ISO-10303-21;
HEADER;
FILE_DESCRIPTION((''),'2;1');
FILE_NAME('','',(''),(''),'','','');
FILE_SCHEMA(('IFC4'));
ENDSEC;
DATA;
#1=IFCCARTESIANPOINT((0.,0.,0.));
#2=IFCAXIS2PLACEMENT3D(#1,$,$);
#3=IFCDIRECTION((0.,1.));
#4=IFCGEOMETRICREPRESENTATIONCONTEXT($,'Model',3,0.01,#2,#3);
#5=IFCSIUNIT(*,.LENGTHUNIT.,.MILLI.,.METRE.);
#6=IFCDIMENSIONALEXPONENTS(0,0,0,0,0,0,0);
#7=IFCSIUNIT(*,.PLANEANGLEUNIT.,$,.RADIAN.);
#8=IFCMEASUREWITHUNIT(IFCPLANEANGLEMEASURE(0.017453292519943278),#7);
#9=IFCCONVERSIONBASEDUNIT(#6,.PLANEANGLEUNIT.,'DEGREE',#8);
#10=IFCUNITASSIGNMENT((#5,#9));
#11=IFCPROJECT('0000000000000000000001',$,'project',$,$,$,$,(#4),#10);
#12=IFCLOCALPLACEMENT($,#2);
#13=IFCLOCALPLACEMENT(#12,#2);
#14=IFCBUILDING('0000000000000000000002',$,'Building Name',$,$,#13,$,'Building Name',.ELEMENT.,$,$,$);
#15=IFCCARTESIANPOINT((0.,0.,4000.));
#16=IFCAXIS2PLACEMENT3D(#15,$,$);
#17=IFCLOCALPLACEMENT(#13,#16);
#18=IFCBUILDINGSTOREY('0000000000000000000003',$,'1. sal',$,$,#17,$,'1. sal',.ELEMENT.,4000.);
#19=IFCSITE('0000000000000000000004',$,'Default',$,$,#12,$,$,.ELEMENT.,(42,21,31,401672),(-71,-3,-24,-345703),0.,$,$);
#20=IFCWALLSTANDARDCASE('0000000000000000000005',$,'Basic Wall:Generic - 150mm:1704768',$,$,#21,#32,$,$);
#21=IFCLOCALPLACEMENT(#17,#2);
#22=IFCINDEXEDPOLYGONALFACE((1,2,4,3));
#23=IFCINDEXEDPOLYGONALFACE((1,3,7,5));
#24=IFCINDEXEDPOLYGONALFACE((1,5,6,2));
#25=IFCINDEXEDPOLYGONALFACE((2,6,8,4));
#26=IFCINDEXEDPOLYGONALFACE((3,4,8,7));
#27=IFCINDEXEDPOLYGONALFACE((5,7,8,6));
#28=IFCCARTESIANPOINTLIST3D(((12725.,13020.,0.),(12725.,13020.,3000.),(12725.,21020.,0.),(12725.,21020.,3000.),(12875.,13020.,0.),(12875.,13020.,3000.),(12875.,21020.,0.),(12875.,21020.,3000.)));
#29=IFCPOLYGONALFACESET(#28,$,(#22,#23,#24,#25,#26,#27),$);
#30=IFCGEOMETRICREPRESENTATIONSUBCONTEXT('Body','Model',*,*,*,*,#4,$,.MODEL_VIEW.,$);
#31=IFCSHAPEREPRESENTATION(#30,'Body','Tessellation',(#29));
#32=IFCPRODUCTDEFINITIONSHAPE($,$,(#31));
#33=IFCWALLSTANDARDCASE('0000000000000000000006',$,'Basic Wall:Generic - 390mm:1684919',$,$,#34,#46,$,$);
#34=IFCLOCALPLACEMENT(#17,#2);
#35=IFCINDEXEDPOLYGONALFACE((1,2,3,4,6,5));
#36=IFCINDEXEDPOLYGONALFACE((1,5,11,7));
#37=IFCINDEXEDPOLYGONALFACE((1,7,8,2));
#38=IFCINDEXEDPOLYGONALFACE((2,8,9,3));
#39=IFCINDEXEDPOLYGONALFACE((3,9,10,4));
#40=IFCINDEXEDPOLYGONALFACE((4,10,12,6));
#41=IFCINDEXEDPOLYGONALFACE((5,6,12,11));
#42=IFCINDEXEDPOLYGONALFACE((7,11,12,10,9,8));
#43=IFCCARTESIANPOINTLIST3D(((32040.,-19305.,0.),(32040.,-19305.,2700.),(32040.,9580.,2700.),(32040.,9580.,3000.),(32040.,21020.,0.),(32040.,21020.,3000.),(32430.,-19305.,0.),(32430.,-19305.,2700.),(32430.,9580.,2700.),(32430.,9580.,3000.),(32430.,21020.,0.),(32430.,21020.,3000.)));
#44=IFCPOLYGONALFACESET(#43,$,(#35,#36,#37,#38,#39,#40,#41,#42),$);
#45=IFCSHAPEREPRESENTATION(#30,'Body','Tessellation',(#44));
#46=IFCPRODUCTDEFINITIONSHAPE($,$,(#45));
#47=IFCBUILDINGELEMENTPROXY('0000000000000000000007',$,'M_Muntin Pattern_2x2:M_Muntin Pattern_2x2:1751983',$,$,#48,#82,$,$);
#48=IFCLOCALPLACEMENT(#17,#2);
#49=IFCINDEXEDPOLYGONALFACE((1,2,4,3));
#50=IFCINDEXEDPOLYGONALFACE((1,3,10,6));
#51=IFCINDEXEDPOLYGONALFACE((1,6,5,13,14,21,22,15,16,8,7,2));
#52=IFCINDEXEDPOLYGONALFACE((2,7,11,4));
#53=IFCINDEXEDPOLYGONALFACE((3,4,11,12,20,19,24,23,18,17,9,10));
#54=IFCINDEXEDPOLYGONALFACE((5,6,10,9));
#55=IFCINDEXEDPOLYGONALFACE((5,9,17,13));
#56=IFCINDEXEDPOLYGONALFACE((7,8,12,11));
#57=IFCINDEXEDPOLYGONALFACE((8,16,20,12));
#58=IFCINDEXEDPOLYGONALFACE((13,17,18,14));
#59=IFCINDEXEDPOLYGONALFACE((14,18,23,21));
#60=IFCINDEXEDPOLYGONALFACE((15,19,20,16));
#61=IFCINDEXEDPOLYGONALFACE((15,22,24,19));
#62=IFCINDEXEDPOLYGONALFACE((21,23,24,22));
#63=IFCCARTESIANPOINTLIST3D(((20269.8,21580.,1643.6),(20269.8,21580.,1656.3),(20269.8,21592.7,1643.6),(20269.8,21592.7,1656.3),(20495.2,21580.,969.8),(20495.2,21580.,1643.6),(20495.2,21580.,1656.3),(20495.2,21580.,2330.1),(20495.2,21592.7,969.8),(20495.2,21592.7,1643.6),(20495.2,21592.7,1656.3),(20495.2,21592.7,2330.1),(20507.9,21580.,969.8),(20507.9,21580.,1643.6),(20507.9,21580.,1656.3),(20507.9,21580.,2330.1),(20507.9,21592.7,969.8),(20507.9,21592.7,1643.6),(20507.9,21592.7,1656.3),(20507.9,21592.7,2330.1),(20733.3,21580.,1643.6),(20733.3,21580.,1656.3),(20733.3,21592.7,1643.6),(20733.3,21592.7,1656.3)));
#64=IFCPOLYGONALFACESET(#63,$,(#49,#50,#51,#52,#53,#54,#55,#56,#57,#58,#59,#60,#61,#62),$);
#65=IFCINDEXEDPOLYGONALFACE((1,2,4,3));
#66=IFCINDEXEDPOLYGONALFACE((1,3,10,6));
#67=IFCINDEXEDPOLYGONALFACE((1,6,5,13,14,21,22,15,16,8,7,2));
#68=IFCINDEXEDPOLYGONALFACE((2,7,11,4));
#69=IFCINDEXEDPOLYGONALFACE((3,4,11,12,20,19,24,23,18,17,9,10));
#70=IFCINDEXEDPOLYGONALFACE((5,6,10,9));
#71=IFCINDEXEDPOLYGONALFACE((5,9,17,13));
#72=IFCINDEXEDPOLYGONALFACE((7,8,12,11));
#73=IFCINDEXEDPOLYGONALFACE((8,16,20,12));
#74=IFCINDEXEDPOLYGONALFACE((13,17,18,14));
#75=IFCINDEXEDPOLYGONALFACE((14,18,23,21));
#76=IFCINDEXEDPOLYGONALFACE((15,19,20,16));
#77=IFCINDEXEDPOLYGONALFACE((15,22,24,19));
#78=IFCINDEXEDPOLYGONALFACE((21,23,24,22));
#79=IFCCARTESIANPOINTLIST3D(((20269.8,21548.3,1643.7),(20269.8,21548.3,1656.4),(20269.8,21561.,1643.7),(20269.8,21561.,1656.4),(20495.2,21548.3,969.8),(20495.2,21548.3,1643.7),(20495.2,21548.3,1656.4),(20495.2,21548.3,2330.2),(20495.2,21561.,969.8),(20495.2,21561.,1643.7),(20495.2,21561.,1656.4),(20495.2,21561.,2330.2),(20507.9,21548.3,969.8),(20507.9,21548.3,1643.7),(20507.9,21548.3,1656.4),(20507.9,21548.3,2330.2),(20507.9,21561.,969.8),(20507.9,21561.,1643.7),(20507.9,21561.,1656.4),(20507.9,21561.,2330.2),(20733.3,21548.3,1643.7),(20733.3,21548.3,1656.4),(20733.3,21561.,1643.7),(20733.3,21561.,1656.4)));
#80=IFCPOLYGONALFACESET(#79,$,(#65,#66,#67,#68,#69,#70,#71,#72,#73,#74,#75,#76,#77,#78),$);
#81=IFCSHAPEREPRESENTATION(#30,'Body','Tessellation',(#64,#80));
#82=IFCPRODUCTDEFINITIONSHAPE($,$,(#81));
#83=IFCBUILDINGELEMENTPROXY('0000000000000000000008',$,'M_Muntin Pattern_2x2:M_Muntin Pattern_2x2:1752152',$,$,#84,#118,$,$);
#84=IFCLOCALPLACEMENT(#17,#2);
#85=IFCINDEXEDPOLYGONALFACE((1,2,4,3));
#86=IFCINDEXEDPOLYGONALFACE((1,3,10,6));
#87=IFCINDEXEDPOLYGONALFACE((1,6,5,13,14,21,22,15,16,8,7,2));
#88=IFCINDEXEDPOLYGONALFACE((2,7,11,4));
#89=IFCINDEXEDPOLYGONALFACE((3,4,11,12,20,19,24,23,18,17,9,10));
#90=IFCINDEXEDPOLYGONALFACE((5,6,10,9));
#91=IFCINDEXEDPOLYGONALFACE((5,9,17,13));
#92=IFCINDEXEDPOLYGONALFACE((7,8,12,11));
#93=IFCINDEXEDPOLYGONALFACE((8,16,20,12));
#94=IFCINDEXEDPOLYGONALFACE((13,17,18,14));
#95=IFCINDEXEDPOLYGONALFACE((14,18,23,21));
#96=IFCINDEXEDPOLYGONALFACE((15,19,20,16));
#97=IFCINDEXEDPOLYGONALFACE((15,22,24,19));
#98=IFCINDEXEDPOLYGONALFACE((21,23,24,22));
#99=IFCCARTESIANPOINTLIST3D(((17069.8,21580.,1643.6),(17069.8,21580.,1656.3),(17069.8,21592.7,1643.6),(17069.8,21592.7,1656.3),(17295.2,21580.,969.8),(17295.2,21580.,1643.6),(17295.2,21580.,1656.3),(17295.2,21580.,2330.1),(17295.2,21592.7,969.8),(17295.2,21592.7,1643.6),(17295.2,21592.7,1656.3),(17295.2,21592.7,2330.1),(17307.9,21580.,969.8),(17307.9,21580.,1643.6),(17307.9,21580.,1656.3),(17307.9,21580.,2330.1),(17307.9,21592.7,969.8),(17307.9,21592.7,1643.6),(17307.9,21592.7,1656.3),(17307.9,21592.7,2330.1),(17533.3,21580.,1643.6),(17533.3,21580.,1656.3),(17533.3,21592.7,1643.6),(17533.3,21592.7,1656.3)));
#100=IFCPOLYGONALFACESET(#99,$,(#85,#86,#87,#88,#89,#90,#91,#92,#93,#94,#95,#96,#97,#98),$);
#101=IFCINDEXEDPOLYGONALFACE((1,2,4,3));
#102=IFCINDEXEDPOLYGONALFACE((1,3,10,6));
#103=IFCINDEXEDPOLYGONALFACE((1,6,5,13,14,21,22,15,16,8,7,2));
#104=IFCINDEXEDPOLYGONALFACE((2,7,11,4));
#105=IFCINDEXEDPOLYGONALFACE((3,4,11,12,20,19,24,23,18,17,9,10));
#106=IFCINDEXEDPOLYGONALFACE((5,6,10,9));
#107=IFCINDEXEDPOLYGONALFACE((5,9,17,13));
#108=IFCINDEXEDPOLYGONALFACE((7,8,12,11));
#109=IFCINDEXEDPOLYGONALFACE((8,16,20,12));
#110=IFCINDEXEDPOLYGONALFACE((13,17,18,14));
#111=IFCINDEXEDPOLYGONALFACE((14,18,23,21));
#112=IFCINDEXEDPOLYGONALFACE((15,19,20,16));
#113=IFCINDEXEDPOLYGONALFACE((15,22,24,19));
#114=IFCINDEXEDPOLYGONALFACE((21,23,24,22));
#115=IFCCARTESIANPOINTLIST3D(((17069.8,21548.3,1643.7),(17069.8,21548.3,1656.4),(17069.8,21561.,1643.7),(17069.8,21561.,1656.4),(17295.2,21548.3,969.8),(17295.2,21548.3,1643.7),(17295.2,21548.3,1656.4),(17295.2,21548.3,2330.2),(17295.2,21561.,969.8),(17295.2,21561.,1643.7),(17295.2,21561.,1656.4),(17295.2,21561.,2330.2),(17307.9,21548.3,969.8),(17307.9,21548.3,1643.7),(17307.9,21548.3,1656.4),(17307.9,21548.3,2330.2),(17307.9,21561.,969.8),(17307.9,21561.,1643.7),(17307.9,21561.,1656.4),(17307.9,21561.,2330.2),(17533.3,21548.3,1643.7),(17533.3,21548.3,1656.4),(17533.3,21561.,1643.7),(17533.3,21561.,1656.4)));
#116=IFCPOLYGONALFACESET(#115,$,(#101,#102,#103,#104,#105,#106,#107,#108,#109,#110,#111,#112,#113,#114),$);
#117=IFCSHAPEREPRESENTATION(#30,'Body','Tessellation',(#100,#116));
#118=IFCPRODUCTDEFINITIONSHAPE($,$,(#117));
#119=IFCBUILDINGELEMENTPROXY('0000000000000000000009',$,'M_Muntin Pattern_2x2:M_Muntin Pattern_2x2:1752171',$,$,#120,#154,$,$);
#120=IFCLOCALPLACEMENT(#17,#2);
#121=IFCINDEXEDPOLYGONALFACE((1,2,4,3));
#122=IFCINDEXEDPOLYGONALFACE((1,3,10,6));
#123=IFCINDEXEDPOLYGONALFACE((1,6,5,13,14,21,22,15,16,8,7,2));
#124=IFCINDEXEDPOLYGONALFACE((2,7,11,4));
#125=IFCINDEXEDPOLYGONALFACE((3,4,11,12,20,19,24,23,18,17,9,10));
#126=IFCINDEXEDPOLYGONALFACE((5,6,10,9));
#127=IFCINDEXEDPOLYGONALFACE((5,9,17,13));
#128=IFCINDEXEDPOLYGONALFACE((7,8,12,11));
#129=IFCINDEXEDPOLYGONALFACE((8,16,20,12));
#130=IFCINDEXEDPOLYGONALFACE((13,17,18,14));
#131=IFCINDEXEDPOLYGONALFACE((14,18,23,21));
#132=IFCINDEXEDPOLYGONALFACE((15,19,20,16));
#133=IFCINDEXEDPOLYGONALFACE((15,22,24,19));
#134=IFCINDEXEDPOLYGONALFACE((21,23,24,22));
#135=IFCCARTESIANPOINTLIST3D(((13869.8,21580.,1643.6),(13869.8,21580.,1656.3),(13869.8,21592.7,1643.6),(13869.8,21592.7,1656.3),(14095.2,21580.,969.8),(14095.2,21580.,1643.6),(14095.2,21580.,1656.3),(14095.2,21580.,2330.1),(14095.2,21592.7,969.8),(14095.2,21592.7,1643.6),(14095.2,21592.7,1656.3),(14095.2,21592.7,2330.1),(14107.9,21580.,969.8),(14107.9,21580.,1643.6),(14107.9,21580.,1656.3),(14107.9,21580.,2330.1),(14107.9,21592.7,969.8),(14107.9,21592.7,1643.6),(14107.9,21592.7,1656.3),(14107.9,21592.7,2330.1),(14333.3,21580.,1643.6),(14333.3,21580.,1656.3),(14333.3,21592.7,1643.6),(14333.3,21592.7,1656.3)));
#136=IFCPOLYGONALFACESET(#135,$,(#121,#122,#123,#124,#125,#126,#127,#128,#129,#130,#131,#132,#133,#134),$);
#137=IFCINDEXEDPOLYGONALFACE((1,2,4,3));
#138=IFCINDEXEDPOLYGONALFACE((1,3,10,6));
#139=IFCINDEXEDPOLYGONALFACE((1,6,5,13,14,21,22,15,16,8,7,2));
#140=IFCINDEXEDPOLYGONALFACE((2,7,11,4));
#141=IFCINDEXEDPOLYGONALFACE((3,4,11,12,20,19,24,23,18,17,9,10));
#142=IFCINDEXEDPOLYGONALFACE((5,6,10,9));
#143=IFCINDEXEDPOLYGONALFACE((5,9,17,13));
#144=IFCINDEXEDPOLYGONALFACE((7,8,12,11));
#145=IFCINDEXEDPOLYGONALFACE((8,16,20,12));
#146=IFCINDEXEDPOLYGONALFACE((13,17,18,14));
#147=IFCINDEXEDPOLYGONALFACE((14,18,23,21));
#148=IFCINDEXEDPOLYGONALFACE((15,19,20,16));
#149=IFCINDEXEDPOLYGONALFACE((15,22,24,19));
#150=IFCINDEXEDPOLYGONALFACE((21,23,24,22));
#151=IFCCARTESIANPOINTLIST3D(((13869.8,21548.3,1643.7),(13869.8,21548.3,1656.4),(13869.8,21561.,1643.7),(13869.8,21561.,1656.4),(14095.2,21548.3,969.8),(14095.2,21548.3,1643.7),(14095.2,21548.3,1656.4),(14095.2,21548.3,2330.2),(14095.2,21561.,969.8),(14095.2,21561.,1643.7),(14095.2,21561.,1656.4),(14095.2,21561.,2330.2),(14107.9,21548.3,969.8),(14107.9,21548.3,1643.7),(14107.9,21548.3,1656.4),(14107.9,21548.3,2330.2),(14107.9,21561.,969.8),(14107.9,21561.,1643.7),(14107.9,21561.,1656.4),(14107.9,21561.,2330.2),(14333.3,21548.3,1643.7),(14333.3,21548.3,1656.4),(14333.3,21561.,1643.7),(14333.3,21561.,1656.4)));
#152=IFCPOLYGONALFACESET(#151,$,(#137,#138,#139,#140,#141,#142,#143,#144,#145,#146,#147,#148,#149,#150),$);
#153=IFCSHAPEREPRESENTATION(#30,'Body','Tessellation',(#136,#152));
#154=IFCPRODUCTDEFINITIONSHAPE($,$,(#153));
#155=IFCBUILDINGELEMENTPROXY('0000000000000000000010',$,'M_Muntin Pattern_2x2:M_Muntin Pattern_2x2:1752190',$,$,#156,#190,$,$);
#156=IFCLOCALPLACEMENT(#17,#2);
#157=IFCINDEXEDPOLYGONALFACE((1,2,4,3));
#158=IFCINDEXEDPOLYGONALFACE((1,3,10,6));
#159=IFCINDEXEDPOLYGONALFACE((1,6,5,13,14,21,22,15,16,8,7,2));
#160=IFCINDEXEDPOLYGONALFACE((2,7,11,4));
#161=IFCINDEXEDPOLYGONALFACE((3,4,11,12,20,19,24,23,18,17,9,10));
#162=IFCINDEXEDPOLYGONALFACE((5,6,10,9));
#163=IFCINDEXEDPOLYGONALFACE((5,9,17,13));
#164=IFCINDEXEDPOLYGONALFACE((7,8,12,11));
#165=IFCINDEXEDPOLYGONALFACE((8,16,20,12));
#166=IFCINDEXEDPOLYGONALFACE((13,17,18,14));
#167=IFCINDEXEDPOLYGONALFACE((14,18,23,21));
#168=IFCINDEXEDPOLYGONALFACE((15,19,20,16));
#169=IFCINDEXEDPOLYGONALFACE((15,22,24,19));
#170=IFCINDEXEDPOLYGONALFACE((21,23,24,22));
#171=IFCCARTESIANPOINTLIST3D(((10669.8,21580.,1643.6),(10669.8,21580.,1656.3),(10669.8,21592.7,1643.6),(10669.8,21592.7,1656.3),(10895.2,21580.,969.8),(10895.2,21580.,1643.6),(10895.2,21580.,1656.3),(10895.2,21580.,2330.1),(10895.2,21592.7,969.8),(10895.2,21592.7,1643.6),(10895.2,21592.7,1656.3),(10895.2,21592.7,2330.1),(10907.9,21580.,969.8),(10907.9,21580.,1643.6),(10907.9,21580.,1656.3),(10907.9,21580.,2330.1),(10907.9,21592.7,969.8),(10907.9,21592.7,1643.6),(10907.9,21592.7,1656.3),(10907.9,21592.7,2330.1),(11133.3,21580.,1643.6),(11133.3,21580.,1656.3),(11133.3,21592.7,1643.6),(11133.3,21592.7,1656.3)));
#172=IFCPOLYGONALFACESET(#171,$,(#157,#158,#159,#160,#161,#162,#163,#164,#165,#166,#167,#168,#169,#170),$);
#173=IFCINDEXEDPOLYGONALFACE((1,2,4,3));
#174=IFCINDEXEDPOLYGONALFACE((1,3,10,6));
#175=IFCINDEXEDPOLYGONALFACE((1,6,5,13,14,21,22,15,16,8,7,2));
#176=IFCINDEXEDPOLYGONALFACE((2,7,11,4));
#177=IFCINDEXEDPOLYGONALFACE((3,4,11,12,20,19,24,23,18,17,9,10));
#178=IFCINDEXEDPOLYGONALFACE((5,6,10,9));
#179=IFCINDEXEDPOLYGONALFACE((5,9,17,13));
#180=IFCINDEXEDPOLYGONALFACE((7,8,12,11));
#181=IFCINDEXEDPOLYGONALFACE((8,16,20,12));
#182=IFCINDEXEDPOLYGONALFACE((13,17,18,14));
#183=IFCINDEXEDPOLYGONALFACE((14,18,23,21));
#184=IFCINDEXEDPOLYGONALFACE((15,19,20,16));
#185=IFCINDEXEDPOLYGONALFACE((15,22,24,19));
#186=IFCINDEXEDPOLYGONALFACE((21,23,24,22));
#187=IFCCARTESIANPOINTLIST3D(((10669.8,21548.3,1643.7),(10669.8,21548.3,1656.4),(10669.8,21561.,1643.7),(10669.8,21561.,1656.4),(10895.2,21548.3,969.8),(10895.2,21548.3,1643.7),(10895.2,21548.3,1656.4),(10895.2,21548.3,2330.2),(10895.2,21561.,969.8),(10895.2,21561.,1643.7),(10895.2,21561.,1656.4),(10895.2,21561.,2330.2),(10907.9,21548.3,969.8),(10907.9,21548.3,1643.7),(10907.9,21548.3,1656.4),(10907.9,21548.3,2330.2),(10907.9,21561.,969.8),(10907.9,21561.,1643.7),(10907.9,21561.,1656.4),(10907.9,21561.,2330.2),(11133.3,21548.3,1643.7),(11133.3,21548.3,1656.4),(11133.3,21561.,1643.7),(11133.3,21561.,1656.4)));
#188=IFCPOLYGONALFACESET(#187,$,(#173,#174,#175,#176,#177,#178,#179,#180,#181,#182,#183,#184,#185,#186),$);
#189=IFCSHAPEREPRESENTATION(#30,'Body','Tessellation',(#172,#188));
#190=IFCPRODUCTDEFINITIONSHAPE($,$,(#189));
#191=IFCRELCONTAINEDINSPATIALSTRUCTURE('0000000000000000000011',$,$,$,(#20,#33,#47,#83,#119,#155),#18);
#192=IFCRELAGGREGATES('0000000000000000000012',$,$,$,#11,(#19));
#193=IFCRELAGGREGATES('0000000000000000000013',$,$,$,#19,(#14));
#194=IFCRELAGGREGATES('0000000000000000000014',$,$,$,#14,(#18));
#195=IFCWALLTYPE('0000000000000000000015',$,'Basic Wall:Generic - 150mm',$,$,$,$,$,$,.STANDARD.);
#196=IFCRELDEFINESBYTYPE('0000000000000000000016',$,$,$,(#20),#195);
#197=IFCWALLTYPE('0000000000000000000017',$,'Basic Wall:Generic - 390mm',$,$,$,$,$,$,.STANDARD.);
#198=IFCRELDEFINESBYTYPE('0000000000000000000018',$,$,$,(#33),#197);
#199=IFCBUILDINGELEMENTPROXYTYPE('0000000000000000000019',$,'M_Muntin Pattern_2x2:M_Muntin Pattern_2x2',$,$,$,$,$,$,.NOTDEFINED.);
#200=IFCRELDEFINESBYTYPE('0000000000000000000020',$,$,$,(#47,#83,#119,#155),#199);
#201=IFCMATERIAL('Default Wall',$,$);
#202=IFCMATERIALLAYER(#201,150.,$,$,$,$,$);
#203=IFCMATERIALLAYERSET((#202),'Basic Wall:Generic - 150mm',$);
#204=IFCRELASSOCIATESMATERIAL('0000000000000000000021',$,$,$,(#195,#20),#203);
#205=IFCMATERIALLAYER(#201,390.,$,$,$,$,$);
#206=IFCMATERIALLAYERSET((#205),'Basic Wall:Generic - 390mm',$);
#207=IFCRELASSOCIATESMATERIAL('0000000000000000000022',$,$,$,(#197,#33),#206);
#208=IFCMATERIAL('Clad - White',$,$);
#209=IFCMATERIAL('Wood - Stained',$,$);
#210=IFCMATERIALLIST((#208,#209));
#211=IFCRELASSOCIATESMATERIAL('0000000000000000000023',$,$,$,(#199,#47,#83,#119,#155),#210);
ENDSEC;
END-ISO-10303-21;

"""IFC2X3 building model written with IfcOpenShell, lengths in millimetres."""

from ifc_helpers import new_model, entity, si_unit, converted_unit, direction, frame, frame_2d, origin, place, context, subcontext, project, spatial, polyline, rectangle, outline, extrude, clip, bounded_halfspace, source, transform, mapped, material, material_list, layer, layer_set, layer_usage, type_object, type_shapes, element, save


model = new_model("IFC2X3")

# Units and contexts
model_context = context("Model", 3, precision=0.01, world=origin(), true_north=direction((0.0, 1.0)))
body_context = subcontext(model_context, "Body", "Model", "MODEL_VIEW")
ifc_project = project(units=[si_unit("LENGTHUNIT", "METRE", prefix="MILLI"), converted_unit("PLANEANGLEUNIT", "DEGREE", entity("IfcPlaneAngleMeasure", 0.017453292519943278), si_unit("PLANEANGLEUNIT", "RADIAN"), dimensions=[0, 0, 0, 0, 0, 0, 0])], contexts=[model_context])

# Site, building, storey
site_placement = place(None, origin())
site = spatial("IfcSite", under=ifc_project, at=site_placement, Name="Default", CompositionType="ELEMENT", RefLatitude=(42, 21, 31, 401672), RefLongitude=(-71, -3, -24, -345703), RefElevation=0.0)
building_placement = place(site_placement, origin())
building = spatial("IfcBuilding", under=site, at=building_placement, Name="Building Name", LongName="Building Name", CompositionType="ELEMENT")
storey_placement = place(building_placement, frame((0.0, 0.0, 4000.0)))
storey = spatial("IfcBuildingStorey", under=building, at=storey_placement, Name="1. sal", LongName="1. sal", CompositionType="ELEMENT", Elevation=4000.0)

# Walls
ifc_material_1 = material(Name="Default Wall")
ifc_layer_1 = layer(ifc_material_1, 150.0)
ifc_layer_set_1 = layer_set([ifc_layer_1], Name="Basic Wall:Generic - 150mm")
ifc_layer_usage_1 = layer_usage(ifc_layer_set_1, "AXIS2", "NEGATIVE", 75.0)
wall_type_1 = type_object("IfcWallType", Name="Basic Wall:Generic - 150mm", PredefinedType="STANDARD", material=ifc_layer_set_1)
wall_1_placement = place(storey_placement, frame((12800.0, 21020.0, 0.0), z_axis=(0.0, 0.0, 1.0), x_axis=(0.0, -1.0, 0.0)))
element("IfcWallStandardCase", 1, at=wall_1_placement, inside=storey, type_object=wall_type_1, material=ifc_layer_usage_1, Name="Basic Wall:Generic - 150mm:1704768", context=body_context, shape_type="SweptSolid", body=[
    extrude(rectangle(XDim=8000.0, YDim=150.0, at=frame_2d((4000.0, 0.0), x_axis=(-1.0, 0.0))), origin(), (0.0, 0.0, 1.0), 3000.0),
])
ifc_layer_2 = layer(ifc_material_1, 390.0)
ifc_layer_set_2 = layer_set([ifc_layer_2], Name="Basic Wall:Generic - 390mm")
ifc_layer_usage_2 = layer_usage(ifc_layer_set_2, "AXIS2", "NEGATIVE", 195.0)
wall_type_2 = type_object("IfcWallType", Name="Basic Wall:Generic - 390mm", PredefinedType="STANDARD", material=ifc_layer_set_2)
wall_2_placement = place(storey_placement, frame((32235.0, 21020.0, 0.0), z_axis=(0.0, 0.0, 1.0), x_axis=(0.0, -1.0, 0.0)))
element("IfcWallStandardCase", 2, at=wall_2_placement, inside=storey, type_object=wall_type_2, material=ifc_layer_usage_2, Name="Basic Wall:Generic - 390mm:1684919", context=body_context, shape_type="Clipping", body=[
    clip(extrude(rectangle(XDim=40325.0, YDim=390.0, at=frame_2d((20162.5, 0.0), x_axis=(-1.0, 0.0))), origin(), (0.0, 0.0, 1.0), 3000.0), bounded_halfspace(frame((11440.0, -195.0, 2700.0), z_axis=(0.0, 0.0, -1.0), x_axis=(-1.0, 0.0, 0.0)), True, frame((11440.0, -195.0, 2700.0)), polyline([(0.0, 0.0), (28675.0, 0.0), (28885.0, 0.0), (28885.0, 385.0), (28885.0, 390.0), (0.0, 390.0), (0.0, 0.0)]))),
])

# Building element proxies
ifc_material_2 = material(Name="Clad - White")
ifc_material_3 = material(Name="Wood - Stained")
ifc_material_list = material_list([ifc_material_2, ifc_material_3])
building_element_proxy_type_1 = type_object("IfcBuildingElementProxyType", Name="M_Muntin Pattern_2x2:M_Muntin Pattern_2x2", PredefinedType="NOTDEFINED", material=ifc_material_list)
shared_shape_1 = source(origin(), body_context, "Body", "SweptSolid", [
    extrude(outline(polyline([(6.4, -6.4), (680.1, -6.4), (680.1, 6.3), (6.4, 6.3), (6.4, 231.7), (-6.3, 231.7), (-6.3, 6.3), (-680.2, 6.3), (-680.2, -6.4), (-6.3, -6.4), (-6.3, -231.7), (6.4, -231.7), (6.4, -6.4)])), frame((0.0, 9.5, 680.1), z_axis=(0.0, 1.0, 0.0), x_axis=(0.0, 0.0, 1.0)), (0.0, 0.0, 1.0), 12.7),
    extrude(outline(polyline([(6.4, -6.4), (680.2, -6.4), (680.2, 6.3), (6.4, 6.3), (6.4, 231.7), (-6.3, 231.7), (-6.3, 6.3), (-680.2, 6.3), (-680.2, -6.4), (-6.3, -6.4), (-6.3, -231.7), (6.4, -231.7), (6.4, -6.4)])), frame((0.0, -22.2, 680.2), z_axis=(0.0, 1.0, 0.0), x_axis=(0.0, 0.0, 1.0)), (0.0, 0.0, 1.0), 12.7),
])
type_shapes(building_element_proxy_type_1, [shared_shape_1])
for number, where, name in (
    (3, (20501.6, 21570.5, 969.8), "M_Muntin Pattern_2x2:M_Muntin Pattern_2x2:1751983"),
    (4, (17301.6, 21570.5, 969.8), "M_Muntin Pattern_2x2:M_Muntin Pattern_2x2:1752152"),
    (5, (14101.6, 21570.5, 969.8), "M_Muntin Pattern_2x2:M_Muntin Pattern_2x2:1752171"),
    (6, (10901.6, 21570.5, 969.8), "M_Muntin Pattern_2x2:M_Muntin Pattern_2x2:1752190"),
):
    element("IfcBuildingElementProxy", number, at=place(storey_placement, frame(where)), inside=storey, type_object=building_element_proxy_type_1, material=ifc_material_list, Name=name, context=body_context, shape_type="MappedRepresentation", body=[
        mapped(shared_shape_1, transform((0.0, 0.0, 0.0), scale=1.0)),
    ])

save(model, "model.ifc")
